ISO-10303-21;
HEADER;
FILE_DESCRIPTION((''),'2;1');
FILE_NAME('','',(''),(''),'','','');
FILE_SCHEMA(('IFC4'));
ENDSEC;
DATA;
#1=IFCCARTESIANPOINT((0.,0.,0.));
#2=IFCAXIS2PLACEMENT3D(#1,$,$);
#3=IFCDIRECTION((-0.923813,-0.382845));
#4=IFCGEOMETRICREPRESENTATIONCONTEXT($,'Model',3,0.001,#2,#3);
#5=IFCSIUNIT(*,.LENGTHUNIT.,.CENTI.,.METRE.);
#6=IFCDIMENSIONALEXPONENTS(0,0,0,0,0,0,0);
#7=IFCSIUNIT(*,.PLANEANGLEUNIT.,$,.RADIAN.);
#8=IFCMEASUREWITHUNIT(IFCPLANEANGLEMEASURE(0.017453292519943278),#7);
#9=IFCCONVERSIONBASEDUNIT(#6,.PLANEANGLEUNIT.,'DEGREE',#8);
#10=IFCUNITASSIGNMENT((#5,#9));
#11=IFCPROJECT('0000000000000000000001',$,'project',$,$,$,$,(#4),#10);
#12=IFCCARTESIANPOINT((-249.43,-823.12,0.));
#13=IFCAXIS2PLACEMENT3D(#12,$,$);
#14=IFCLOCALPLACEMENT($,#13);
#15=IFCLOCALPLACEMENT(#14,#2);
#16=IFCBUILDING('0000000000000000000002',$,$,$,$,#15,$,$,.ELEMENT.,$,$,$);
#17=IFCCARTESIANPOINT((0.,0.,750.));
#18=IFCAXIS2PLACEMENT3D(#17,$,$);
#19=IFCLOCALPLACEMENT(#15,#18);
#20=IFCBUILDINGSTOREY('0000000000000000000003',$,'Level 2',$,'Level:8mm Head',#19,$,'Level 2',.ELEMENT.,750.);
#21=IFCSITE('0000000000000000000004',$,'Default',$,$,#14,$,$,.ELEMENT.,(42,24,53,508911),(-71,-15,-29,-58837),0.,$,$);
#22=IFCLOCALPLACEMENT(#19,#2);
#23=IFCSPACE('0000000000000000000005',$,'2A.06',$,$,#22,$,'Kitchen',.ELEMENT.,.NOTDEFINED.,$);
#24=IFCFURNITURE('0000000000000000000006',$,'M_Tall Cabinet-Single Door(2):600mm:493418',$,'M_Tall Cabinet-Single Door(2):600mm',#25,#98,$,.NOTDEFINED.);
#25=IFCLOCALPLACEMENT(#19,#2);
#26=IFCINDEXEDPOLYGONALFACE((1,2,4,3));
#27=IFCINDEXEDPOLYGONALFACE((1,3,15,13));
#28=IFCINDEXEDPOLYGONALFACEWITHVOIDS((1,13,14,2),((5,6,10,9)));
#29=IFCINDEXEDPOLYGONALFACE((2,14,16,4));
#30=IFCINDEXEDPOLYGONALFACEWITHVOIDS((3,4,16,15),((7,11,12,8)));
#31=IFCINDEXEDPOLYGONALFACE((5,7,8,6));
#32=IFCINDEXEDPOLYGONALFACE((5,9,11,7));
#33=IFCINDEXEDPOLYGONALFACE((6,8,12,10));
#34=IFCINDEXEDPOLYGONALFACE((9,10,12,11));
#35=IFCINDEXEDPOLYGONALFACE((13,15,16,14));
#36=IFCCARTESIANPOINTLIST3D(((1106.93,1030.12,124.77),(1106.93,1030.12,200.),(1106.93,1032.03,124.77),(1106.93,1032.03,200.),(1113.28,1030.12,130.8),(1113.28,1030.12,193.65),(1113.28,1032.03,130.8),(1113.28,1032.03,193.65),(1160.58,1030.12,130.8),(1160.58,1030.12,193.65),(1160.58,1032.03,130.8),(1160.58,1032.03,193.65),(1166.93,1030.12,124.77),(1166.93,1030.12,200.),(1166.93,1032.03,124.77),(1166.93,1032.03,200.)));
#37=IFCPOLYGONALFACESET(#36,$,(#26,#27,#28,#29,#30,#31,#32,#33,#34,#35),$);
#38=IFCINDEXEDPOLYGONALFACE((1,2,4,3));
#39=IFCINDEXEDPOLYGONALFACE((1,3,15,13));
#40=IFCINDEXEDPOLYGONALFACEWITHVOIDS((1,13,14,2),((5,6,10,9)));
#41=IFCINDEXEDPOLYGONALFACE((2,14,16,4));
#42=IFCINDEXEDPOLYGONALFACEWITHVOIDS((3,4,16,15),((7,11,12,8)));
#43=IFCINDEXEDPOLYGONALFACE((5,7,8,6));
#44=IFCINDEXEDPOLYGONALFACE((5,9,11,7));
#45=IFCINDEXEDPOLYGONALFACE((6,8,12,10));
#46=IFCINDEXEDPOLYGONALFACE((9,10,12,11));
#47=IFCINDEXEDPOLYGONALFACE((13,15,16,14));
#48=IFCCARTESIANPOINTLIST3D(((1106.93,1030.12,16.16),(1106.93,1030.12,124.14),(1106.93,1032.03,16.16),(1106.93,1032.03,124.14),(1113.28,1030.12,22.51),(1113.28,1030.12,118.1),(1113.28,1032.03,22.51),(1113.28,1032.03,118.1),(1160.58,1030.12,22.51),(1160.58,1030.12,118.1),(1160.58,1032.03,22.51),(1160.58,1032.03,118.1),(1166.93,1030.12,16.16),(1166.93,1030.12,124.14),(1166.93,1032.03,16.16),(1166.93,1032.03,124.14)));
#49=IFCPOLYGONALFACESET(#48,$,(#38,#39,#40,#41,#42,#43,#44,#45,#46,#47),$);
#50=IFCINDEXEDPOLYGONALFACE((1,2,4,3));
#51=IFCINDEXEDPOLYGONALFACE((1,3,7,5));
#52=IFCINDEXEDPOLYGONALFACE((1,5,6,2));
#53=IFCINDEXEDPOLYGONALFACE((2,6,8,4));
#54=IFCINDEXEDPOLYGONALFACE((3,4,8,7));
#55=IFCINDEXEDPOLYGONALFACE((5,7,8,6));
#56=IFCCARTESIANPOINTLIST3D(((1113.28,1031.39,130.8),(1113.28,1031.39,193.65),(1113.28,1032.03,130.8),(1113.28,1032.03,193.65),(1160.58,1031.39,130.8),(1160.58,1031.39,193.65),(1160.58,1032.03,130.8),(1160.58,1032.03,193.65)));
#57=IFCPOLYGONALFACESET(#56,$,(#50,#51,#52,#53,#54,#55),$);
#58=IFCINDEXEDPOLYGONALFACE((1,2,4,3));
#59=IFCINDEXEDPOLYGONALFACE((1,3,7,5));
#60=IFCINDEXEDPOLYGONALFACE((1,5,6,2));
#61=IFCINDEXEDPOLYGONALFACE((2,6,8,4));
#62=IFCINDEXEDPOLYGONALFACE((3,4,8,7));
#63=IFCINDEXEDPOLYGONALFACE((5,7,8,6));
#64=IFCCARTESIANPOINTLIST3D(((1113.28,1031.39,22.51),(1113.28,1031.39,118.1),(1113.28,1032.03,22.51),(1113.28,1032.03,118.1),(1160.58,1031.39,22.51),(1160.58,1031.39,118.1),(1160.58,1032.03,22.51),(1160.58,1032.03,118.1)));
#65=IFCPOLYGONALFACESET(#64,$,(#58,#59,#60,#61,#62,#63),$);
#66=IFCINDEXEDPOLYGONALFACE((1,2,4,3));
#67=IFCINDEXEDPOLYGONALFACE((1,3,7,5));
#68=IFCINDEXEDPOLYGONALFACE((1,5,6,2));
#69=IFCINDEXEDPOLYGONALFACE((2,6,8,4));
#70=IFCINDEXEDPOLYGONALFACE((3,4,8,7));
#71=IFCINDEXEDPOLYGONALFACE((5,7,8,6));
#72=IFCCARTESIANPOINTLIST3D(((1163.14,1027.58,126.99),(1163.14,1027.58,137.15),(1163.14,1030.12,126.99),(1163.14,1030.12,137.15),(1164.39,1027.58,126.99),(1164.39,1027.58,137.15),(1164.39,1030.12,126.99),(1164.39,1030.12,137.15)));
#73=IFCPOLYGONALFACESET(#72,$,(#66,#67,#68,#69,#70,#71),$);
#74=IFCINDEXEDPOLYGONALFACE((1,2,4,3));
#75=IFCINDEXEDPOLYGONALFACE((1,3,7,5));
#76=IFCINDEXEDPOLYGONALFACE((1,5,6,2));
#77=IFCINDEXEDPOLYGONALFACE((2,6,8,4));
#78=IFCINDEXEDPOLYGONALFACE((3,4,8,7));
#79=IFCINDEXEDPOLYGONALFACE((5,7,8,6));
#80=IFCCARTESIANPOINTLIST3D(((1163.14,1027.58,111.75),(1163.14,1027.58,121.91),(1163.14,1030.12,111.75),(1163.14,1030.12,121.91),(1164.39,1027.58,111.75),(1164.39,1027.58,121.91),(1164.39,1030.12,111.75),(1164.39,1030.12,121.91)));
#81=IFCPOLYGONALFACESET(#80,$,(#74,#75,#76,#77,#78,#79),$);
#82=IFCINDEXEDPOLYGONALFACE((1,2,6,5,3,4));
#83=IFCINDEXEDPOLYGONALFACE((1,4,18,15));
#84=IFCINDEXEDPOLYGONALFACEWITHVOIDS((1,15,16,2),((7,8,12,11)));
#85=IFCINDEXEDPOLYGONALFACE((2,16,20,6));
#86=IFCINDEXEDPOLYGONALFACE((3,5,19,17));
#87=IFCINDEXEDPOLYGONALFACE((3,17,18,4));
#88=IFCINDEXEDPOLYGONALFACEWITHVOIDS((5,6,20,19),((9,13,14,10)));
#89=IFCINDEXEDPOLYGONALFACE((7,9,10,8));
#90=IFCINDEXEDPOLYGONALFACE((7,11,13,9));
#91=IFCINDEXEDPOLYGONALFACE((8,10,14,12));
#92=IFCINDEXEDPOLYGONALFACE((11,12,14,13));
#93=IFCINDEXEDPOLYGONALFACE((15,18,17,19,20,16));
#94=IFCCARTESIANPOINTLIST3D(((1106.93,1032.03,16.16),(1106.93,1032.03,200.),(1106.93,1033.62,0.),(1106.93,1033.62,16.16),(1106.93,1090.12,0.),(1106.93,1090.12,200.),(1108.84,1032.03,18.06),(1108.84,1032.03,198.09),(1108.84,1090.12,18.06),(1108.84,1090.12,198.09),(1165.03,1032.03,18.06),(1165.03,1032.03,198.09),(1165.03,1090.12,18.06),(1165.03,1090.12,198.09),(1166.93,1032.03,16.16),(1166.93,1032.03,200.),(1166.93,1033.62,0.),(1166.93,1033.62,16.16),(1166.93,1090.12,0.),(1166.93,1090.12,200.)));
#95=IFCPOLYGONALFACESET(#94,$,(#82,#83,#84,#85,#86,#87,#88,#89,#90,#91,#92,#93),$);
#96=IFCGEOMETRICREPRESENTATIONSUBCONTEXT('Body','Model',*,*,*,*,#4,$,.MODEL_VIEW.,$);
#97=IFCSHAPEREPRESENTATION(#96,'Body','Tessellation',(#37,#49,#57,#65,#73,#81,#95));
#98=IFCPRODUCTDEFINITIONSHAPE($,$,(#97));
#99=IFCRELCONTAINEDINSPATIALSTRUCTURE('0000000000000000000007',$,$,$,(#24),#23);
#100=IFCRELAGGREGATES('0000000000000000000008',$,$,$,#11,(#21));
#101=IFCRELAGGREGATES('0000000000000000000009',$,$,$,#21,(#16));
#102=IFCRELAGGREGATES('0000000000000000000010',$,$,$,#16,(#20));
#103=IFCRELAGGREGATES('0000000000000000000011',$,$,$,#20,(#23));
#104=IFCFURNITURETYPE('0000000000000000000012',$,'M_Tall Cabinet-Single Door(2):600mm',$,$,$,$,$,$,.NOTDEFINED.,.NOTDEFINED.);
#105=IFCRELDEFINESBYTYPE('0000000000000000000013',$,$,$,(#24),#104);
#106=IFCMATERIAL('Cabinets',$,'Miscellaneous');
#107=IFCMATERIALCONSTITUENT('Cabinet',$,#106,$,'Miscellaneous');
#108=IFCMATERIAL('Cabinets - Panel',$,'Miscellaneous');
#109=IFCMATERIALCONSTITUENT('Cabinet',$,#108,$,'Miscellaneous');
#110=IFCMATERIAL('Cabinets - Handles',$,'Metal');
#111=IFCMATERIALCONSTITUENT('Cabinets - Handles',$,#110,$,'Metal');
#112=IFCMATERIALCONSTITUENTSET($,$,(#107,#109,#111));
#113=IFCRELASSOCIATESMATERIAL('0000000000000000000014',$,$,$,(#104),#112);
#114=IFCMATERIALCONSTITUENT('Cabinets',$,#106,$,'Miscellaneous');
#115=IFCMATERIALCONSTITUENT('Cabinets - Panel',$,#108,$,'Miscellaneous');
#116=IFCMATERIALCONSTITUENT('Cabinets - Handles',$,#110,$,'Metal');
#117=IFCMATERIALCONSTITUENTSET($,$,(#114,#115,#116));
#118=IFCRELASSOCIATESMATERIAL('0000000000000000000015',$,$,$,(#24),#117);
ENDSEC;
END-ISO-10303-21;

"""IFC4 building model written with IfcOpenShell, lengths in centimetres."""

from ifc_helpers import new_model, entity, si_unit, converted_unit, direction, frame, origin, place, context, subcontext, project, spatial, indexed_curve, outline, extrude, source, transform, mapped, material, constituent, constituent_set, type_object, type_shapes, element, save


model = new_model("IFC4")

# Units and contexts
model_context = context("Model", 3, precision=0.001, world=origin(), true_north=direction((-0.923813, -0.382845)))
body_context = subcontext(model_context, "Body", "Model", "MODEL_VIEW")
ifc_project = project(units=[si_unit("LENGTHUNIT", "METRE", prefix="CENTI"), converted_unit("PLANEANGLEUNIT", "DEGREE", entity("IfcPlaneAngleMeasure", 0.017453292519943278), si_unit("PLANEANGLEUNIT", "RADIAN"), dimensions=[0, 0, 0, 0, 0, 0, 0])], contexts=[model_context])

# Site, building, storey
site_placement = place(None, frame((-249.43, -823.12, 0.0)))
site = spatial("IfcSite", under=ifc_project, at=site_placement, Name="Default", CompositionType="ELEMENT", RefLatitude=(42, 24, 53, 508911), RefLongitude=(-71, -15, -29, -58837), RefElevation=0.0)
building_placement = place(site_placement, origin())
building = spatial("IfcBuilding", under=site, at=building_placement, CompositionType="ELEMENT")
storey_placement = place(building_placement, frame((0.0, 0.0, 750.0)))
storey = spatial("IfcBuildingStorey", under=building, at=storey_placement, Name="Level 2", ObjectType="Level:8mm Head", LongName="Level 2", CompositionType="ELEMENT", Elevation=750.0)

# Shared definitions
space_1_placement = place(storey_placement, origin())
space_1 = spatial("IfcSpace", under=storey, at=space_1_placement, Name="2A.06", LongName="Kitchen", CompositionType="ELEMENT", PredefinedType="NOTDEFINED")

# Furniture, opening
ifc_material_1 = material(Name="Cabinets", Category="Miscellaneous")
ifc_material_2 = material(Name="Cabinets - Panel", Category="Miscellaneous")
ifc_material_3 = material(Name="Cabinets - Handles", Category="Metal")
ifc_constituent_1 = constituent(ifc_material_1, Name="Cabinets", Category="Miscellaneous")
ifc_constituent_2 = constituent(ifc_material_2, Name="Cabinets - Panel", Category="Miscellaneous")
ifc_constituent_3 = constituent(ifc_material_3, Name="Cabinets - Handles", Category="Metal")
ifc_constituent_set_1 = constituent_set(constituents=[ifc_constituent_1, ifc_constituent_2, ifc_constituent_3])
ifc_constituent_4 = constituent(ifc_material_1, Name="Cabinet", Category="Miscellaneous")
ifc_constituent_5 = constituent(ifc_material_2, Name="Cabinet", Category="Miscellaneous")
ifc_constituent_6 = constituent(ifc_material_3, Name="Cabinets - Handles", Category="Metal")
ifc_constituent_set_2 = constituent_set(constituents=[ifc_constituent_4, ifc_constituent_5, ifc_constituent_6])
furniture_type_1 = type_object("IfcFurnitureType", Name="M_Tall Cabinet-Single Door(2):600mm", AssemblyPlace="NOTDEFINED", PredefinedType="NOTDEFINED", material=ifc_constituent_set_2)
shared_shape_1 = source(origin(), body_context, "Body", "SweptSolid", [
    extrude(outline(indexed_curve([(-0.95, -28.09), (0.95, -28.09), (0.95, 28.09), (-0.95, 28.09), (-0.95, -28.09)], self_intersect=False)), frame((1.87, -0.95, 18.06), z_axis=(0.0, 0.0, 1.0), x_axis=(0.0, 1.0, 0.0)), (0.0, 0.0, 1.0), 180.03),
    extrude(outline(indexed_curve([(-37.61, -30.0), (37.61, -30.0), (37.61, 30.0), (-37.61, 30.0), (-37.61, -30.0)], self_intersect=False), holes=[indexed_curve([(-31.26, -23.65), (-31.26, 23.65), (31.58, 23.65), (31.58, -23.65), (-31.26, -23.65)], self_intersect=False)]), frame((1.87, -60.0, 162.39), z_axis=(0.0, 1.0, 0.0), x_axis=(0.0, 0.0, -1.0)), (0.0, 0.0, 1.0), 1.91),
    extrude(outline(indexed_curve([(-30.0, -53.99), (30.0, -53.99), (30.0, 53.99), (-30.0, 53.99), (-30.0, -53.99)], self_intersect=False), holes=[indexed_curve([(-23.65, 47.96), (23.65, 47.96), (23.65, -47.64), (-23.65, -47.64), (-23.65, 47.96)], self_intersect=False)]), frame((1.87, -60.0, 70.15), z_axis=(0.0, 1.0, 0.0), x_axis=(-1.0, 0.0, 0.0)), (0.0, 0.0, 1.0), 1.91),
    extrude(outline(indexed_curve([(-0.32, -23.65), (0.32, -23.65), (0.32, 23.65), (-0.32, 23.65), (-0.32, -23.65)], self_intersect=False)), frame((1.87, -58.41, 130.8), z_axis=(0.0, 0.0, 1.0), x_axis=(0.0, 1.0, 0.0)), (0.0, 0.0, 1.0), 62.85),
    extrude(outline(indexed_curve([(-0.32, -23.65), (0.32, -23.65), (0.32, 23.65), (-0.32, 23.65), (-0.32, -23.65)], self_intersect=False)), frame((1.87, -58.41, 22.51), z_axis=(0.0, 0.0, 1.0), x_axis=(0.0, 1.0, 0.0)), (0.0, 0.0, 1.0), 95.6),
    extrude(outline(indexed_curve([(-1.27, -0.63), (1.27, -0.63), (1.27, 0.63), (-1.27, 0.63), (-1.27, -0.63)], self_intersect=False)), frame((28.71, -61.27, 126.99), z_axis=(0.0, 0.0, 1.0), x_axis=(0.0, 1.0, 0.0)), (0.0, 0.0, 1.0), 10.16),
    extrude(outline(indexed_curve([(-1.27, -0.63), (1.27, -0.63), (1.27, 0.63), (-1.27, 0.63), (-1.27, -0.63)], self_intersect=False)), frame((28.71, -61.27, 111.75), z_axis=(0.0, 0.0, 1.0), x_axis=(0.0, 1.0, 0.0)), (0.0, 0.0, 1.0), 10.16),
    extrude(outline(indexed_curve([(-19.9, 55.89), (-19.9, -127.95), (38.2, -127.95), (38.2, 72.05), (-18.3, 72.05), (-18.3, 55.89), (-19.9, 55.89)], self_intersect=False)), frame((-28.13, -38.2, 72.05), z_axis=(-1.0, 0.0, 0.0), x_axis=(0.0, 1.0, 0.0)), (0.0, 0.0, -1.0), 60.0),
])
type_shapes(furniture_type_1, [shared_shape_1])
furniture_1_placement = place(space_1_placement, frame((1135.06, 1090.12, 0.0)))
furniture_1 = element("IfcFurniture", 1, at=furniture_1_placement, inside=space_1, type_object=furniture_type_1, material=ifc_constituent_set_1, Name="M_Tall Cabinet-Single Door(2):600mm:493418", ObjectType="M_Tall Cabinet-Single Door(2):600mm", PredefinedType="NOTDEFINED", context=body_context, shape_type="MappedRepresentation", body=[
    mapped(shared_shape_1, transform((0.0, 0.0, 0.0), scale=1.0)),
])
opening_1_placement = place(storey_placement, frame((1135.06, 1090.12, 750.0)))
element("IfcOpeningElement", 2, at=opening_1_placement, cuts=furniture_1, PredefinedType="OPENING", context=body_context, shape_type="SweptSolid", body=[
    extrude(outline(indexed_curve([(-28.09, -90.02), (28.09, -90.02), (28.09, 90.02), (-28.09, 90.02), (-28.09, -90.02)], self_intersect=False)), frame((1.87, 0.0, -641.92), z_axis=(0.0, -1.0, 0.0), x_axis=(-1.0, 0.0, 0.0)), (0.0, 0.0, 1.0), 58.09),
])

save(model, "model.ifc")
